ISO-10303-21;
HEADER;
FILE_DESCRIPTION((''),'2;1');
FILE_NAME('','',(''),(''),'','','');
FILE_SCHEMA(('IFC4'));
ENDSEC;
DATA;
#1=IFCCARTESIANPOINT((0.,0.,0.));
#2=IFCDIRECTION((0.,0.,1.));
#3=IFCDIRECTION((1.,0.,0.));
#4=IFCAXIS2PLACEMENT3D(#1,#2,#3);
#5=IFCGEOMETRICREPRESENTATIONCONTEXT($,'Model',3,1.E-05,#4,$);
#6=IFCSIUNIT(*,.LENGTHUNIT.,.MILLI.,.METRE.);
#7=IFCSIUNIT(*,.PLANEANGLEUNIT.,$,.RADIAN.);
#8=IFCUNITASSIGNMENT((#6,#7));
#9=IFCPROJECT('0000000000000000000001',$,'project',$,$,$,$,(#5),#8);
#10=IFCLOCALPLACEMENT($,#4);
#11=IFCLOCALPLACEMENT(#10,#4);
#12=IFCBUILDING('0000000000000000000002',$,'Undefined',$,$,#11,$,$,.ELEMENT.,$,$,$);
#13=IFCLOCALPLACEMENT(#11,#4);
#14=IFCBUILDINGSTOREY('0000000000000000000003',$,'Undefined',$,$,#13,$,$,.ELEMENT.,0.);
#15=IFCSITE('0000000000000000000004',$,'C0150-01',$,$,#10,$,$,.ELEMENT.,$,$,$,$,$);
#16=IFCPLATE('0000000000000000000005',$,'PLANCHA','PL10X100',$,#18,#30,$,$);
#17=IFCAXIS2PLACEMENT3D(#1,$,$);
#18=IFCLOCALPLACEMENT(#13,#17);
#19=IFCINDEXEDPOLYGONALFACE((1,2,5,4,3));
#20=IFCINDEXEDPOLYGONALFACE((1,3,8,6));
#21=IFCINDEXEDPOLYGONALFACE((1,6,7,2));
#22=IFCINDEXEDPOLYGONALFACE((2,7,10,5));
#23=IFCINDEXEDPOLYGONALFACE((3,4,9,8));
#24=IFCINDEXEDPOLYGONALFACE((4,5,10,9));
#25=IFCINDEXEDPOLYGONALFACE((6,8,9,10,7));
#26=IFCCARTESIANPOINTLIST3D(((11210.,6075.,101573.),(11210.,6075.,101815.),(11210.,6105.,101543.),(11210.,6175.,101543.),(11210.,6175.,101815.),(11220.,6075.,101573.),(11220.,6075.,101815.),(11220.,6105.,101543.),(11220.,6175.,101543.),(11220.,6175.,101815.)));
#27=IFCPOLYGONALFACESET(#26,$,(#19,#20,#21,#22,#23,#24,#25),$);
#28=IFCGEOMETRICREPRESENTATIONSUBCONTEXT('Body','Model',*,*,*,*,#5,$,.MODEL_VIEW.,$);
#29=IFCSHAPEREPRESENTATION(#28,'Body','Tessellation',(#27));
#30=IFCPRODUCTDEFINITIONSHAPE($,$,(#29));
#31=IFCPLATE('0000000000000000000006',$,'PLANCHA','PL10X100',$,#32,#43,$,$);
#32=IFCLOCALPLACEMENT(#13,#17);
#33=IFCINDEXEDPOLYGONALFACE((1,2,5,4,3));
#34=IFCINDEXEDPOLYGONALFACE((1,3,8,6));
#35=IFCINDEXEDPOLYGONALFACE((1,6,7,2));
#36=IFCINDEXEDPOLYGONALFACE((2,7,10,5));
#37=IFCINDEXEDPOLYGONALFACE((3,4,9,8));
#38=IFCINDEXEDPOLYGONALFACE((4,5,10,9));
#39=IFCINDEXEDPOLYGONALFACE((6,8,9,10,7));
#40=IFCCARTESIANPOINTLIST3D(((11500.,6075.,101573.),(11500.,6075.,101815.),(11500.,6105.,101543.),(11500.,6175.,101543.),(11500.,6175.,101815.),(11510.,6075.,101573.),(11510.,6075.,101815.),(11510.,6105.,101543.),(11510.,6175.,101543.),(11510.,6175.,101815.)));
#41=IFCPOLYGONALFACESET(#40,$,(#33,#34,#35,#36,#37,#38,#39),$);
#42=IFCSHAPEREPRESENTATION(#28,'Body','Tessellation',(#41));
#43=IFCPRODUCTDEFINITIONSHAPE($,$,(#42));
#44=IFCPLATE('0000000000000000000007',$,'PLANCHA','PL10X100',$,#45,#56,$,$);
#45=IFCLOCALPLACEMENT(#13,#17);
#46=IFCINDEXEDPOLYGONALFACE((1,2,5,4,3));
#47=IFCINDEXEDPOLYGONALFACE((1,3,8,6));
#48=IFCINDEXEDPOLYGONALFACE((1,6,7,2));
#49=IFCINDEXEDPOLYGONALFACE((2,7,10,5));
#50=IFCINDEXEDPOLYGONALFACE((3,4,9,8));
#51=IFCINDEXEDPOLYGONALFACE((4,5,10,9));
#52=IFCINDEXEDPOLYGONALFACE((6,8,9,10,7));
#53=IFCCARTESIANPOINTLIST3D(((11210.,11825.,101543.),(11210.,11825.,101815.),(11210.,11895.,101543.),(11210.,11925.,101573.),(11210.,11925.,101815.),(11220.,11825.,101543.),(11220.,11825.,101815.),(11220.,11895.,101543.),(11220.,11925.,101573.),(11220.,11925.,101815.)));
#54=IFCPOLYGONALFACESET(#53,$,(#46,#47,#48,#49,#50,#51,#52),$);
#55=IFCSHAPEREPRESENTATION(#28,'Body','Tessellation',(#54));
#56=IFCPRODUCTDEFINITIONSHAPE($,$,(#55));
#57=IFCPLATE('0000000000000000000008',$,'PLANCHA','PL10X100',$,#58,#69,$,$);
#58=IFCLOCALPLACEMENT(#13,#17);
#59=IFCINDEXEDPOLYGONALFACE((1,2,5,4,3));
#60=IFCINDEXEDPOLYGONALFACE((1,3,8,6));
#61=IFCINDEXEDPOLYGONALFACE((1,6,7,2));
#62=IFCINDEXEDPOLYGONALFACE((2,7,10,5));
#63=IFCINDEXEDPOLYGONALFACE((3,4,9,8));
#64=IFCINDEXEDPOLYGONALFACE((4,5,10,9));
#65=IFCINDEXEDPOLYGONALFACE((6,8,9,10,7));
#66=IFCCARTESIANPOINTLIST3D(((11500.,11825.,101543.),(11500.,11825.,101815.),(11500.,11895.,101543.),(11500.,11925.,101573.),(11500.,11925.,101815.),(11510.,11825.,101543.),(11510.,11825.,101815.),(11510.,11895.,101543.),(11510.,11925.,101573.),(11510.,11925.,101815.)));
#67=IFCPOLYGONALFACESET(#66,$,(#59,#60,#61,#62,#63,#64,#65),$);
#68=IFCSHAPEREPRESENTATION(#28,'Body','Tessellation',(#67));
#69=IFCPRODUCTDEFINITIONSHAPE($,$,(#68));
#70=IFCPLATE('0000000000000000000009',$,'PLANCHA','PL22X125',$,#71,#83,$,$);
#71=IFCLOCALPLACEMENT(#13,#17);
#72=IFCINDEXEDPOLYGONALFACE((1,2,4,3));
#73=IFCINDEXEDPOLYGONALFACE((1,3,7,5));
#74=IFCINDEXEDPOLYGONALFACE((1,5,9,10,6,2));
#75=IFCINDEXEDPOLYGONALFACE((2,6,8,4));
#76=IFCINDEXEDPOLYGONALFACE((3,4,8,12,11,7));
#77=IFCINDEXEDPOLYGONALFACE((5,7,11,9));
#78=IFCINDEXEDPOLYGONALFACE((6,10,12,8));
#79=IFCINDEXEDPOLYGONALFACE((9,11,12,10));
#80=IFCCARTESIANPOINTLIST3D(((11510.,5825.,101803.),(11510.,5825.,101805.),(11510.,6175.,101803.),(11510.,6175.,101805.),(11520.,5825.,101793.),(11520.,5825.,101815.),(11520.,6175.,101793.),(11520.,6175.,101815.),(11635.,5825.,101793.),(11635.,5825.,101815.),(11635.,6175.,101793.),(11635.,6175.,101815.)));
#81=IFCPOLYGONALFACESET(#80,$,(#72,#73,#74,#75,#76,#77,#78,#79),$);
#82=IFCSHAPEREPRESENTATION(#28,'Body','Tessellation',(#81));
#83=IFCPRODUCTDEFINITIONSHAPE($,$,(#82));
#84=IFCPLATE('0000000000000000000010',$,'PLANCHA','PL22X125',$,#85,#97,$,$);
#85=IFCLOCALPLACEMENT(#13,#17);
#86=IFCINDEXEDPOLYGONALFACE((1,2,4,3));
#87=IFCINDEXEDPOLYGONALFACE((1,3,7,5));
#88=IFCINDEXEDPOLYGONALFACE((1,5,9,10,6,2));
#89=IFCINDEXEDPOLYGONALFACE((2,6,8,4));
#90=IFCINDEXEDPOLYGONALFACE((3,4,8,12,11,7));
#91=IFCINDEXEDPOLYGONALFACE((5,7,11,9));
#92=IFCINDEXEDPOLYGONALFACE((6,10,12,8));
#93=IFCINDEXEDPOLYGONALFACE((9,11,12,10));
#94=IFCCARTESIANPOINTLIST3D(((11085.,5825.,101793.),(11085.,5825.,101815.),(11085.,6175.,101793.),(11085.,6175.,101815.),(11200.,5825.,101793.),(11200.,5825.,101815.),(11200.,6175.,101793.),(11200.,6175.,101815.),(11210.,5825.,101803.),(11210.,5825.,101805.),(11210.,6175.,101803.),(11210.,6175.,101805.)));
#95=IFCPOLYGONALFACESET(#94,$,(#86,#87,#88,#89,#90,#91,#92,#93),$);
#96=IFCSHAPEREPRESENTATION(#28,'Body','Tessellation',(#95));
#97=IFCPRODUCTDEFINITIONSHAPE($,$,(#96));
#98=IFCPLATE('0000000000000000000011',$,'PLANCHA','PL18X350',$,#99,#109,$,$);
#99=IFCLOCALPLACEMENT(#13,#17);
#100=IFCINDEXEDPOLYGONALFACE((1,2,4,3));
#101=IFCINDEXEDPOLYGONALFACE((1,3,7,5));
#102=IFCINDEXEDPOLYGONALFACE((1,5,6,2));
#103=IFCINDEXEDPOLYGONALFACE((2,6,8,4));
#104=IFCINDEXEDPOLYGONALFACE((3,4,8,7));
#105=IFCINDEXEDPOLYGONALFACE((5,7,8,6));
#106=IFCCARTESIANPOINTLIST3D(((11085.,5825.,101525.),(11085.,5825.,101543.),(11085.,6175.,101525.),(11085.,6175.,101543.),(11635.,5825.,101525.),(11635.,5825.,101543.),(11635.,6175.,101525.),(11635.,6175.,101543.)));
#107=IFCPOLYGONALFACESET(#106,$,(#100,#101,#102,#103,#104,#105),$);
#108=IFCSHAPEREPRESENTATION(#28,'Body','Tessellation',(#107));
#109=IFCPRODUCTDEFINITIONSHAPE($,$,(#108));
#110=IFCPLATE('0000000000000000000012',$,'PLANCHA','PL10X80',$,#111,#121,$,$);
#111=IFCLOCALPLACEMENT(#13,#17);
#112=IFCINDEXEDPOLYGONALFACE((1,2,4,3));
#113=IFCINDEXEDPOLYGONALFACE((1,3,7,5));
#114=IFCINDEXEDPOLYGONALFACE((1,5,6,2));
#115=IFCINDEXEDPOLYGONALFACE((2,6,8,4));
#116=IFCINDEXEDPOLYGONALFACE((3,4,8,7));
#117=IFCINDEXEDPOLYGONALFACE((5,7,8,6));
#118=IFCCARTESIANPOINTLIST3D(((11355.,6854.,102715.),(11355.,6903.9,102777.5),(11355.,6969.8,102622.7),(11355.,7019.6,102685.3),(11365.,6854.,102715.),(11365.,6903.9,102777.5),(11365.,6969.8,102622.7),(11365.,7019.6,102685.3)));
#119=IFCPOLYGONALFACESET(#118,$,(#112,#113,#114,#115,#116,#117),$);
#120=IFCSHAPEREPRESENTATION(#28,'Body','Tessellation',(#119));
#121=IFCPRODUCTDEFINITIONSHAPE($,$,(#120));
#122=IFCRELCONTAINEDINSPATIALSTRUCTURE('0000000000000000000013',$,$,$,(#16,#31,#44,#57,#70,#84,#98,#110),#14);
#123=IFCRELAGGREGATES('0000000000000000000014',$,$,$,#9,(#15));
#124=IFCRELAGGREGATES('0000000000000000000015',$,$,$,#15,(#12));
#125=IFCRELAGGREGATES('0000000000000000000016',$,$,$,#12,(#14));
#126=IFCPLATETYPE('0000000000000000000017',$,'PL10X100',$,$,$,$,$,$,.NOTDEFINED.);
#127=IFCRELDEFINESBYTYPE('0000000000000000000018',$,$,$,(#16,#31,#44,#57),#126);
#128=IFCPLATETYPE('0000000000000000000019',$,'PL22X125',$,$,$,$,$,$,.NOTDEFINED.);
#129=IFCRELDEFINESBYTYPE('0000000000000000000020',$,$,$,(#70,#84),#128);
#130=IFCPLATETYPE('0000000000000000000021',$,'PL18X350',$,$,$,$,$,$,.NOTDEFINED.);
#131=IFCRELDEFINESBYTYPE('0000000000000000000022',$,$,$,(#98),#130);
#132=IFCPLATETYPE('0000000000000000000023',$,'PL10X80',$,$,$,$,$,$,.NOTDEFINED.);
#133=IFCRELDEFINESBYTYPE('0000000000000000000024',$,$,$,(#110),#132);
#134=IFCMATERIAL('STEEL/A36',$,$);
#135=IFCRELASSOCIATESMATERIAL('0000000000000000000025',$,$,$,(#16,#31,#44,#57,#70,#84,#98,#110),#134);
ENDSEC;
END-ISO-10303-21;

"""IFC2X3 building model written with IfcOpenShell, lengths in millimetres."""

from ifc_helpers import new_model, si_unit, frame, origin_with_axes, place, context, subcontext, project, spatial, polyline, outline, extrude, boolean, material, type_object, element, save


model = new_model("IFC2X3")

# Units and contexts
model_context = context("Model", 3, precision=1e-05, world=origin_with_axes())
body_context = subcontext(model_context, "Body", "Model", "MODEL_VIEW")
ifc_project = project(units=[si_unit("LENGTHUNIT", "METRE", prefix="MILLI"), si_unit("PLANEANGLEUNIT", "RADIAN")], contexts=[model_context])

# Site, building, storey
site_placement = place(None, origin_with_axes())
site = spatial("IfcSite", under=ifc_project, at=site_placement, Name="C0150-01", CompositionType="ELEMENT")
building_placement = place(site_placement, origin_with_axes())
building = spatial("IfcBuilding", under=site, at=building_placement, Name="Undefined", CompositionType="ELEMENT")
storey_placement = place(building_placement, origin_with_axes())
storey = spatial("IfcBuildingStorey", under=building, at=storey_placement, Name="Undefined", CompositionType="ELEMENT", Elevation=0.0)

# Shared definitions
ifc_material_1 = material(Name="STEEL/A36")

# Plates
plate_type_1 = type_object("IfcPlateType", Name="PL10X100", PredefinedType="NOTDEFINED")
for number, where, z_axis, x_axis, name in (
    (1, (11215.0, 6175.0, 101815.0), (-1.0, 0.0, 0.0), (0.0, 0.0, -1.0), "PLANCHA"),
    (2, (11505.0, 6175.0, 101815.0), (-1.0, 0.0, 0.0), (0.0, 0.0, -1.0), "PLANCHA"),
    (3, (11215.0, 11825.0, 101815.0), (1.0, 0.0, 0.0), (0.0, 0.0, -1.0), "PLANCHA"),
    (4, (11505.0, 11825.0, 101815.0), (1.0, 0.0, 0.0), (0.0, 0.0, -1.0), "PLANCHA"),
):
    element("IfcPlate", number, at=place(storey_placement, frame(where, z_axis=z_axis, x_axis=x_axis)), inside=storey, type_object=plate_type_1, material=ifc_material_1, Name=name, Description="PL10X100", context=body_context, shape_type="SweptSolid", body=[
        extrude(outline(polyline([(0.0, 0.0), (272.0, 0.0), (272.0, 70.0), (242.0, 100.0), (0.0, 100.0), (0.0, 0.0)])), frame((0.0, 0.0, -5.0), z_axis=(0.0, 0.0, 1.0), x_axis=(1.0, 0.0, 0.0)), (0.0, 0.0, 1.0), 10.0),
    ])
plate_type_2 = type_object("IfcPlateType", Name="PL22X125", PredefinedType="NOTDEFINED")
plate_1_placement = place(storey_placement, frame((11510.0, 6175.0, 101804.0), z_axis=(0.0, 0.0, 1.0), x_axis=(0.0, -1.0, 0.0)))
element("IfcPlate", 5, at=plate_1_placement, inside=storey, type_object=plate_type_2, material=ifc_material_1, Name="PLANCHA", Description="PL22X125", context=body_context, shape_type="CSG", body=[
    boolean("DIFFERENCE", boolean("DIFFERENCE", extrude(outline(polyline([(0.0, 0.0), (350.0, 0.0), (350.0, 125.0), (0.0, 125.0), (0.0, 0.0)])), frame((0.0, 0.0, -11.0), z_axis=(0.0, 0.0, 1.0), x_axis=(1.0, 0.0, 0.0)), (0.0, 0.0, 1.0), 22.0), extrude(outline(polyline([(0.0, 0.0), (10.0, 0.0), (10.0, 10.0), (0.0, 0.0)])), frame((352.5, 0.0, 1.0), z_axis=(-1.0, 0.0, 0.0), x_axis=(0.0, 0.0, 1.0)), (0.0, 0.0, 1.0), 355.0)), extrude(outline(polyline([(0.0, 0.0), (10.0, 0.0), (10.0, 10.0), (0.0, 0.0)])), frame((-2.5, 0.0, -1.0), z_axis=(1.0, 0.0, 0.0), x_axis=(0.0, 0.0, -1.0)), (0.0, 0.0, 1.0), 355.0)),
])
plate_2_placement = place(storey_placement, frame((11210.0, 6175.0, 101804.0), z_axis=(0.0, 0.0, -1.0), x_axis=(0.0, -1.0, 0.0)))
element("IfcPlate", 6, at=plate_2_placement, inside=storey, type_object=plate_type_2, material=ifc_material_1, Name="PLANCHA", Description="PL22X125", context=body_context, shape_type="CSG", body=[
    boolean("DIFFERENCE", boolean("DIFFERENCE", extrude(outline(polyline([(0.0, 0.0), (350.0, 0.0), (350.0, 125.0), (0.0, 125.0), (0.0, 0.0)])), frame((0.0, 0.0, -11.0), z_axis=(0.0, 0.0, 1.0), x_axis=(1.0, 0.0, 0.0)), (0.0, 0.0, 1.0), 22.0), extrude(outline(polyline([(0.0, 0.0), (10.0, 0.0), (10.0, 10.0), (0.0, 0.0)])), frame((-2.5, 0.0, -1.0), z_axis=(1.0, 0.0, 0.0), x_axis=(0.0, 0.0, -1.0)), (0.0, 0.0, 1.0), 355.0)), extrude(outline(polyline([(0.0, 0.0), (10.0, 0.0), (10.0, 10.0), (0.0, 0.0)])), frame((352.5, 0.0, 1.0), z_axis=(-1.0, 0.0, 0.0), x_axis=(0.0, 0.0, 1.0)), (0.0, 0.0, 1.0), 355.0)),
])
plate_type_3 = type_object("IfcPlateType", Name="PL18X350", PredefinedType="NOTDEFINED")
plate_3_placement = place(storey_placement, frame((11635.0, 6175.0, 101534.0), z_axis=(0.0, 0.0, -1.0), x_axis=(0.0, -1.0, 0.0)))
element("IfcPlate", 7, at=plate_3_placement, inside=storey, type_object=plate_type_3, material=ifc_material_1, Name="PLANCHA", Description="PL18X350", context=body_context, shape_type="SweptSolid", body=[
    extrude(outline(polyline([(0.0, 0.0), (350.0, 0.0), (350.0, 550.0), (0.0, 550.0), (0.0, 0.0)])), frame((0.0, 0.0, -9.0), z_axis=(0.0, 0.0, 1.0), x_axis=(1.0, 0.0, 0.0)), (0.0, 0.0, 1.0), 18.0),
])
plate_type_4 = type_object("IfcPlateType", Name="PL10X80", PredefinedType="NOTDEFINED")
plate_4_placement = place(storey_placement, frame((11360.0, 6903.9, 102777.5), z_axis=(1.0, 0.0, 0.0), x_axis=(0.0, -0.623376, -0.781922)))
element("IfcPlate", 8, at=plate_4_placement, inside=storey, type_object=plate_type_4, material=ifc_material_1, Name="PLANCHA", Description="PL10X80", context=body_context, shape_type="SweptSolid", body=[
    extrude(outline(polyline([(0.0, 0.0), (80.0, 0.0), (80.0, 148.0), (0.0, 148.0), (0.0, 0.0)])), frame((0.0, 0.0, -5.0), z_axis=(0.0, 0.0, 1.0), x_axis=(1.0, 0.0, 0.0)), (0.0, 0.0, 1.0), 10.0),
])

save(model, "model.ifc")
